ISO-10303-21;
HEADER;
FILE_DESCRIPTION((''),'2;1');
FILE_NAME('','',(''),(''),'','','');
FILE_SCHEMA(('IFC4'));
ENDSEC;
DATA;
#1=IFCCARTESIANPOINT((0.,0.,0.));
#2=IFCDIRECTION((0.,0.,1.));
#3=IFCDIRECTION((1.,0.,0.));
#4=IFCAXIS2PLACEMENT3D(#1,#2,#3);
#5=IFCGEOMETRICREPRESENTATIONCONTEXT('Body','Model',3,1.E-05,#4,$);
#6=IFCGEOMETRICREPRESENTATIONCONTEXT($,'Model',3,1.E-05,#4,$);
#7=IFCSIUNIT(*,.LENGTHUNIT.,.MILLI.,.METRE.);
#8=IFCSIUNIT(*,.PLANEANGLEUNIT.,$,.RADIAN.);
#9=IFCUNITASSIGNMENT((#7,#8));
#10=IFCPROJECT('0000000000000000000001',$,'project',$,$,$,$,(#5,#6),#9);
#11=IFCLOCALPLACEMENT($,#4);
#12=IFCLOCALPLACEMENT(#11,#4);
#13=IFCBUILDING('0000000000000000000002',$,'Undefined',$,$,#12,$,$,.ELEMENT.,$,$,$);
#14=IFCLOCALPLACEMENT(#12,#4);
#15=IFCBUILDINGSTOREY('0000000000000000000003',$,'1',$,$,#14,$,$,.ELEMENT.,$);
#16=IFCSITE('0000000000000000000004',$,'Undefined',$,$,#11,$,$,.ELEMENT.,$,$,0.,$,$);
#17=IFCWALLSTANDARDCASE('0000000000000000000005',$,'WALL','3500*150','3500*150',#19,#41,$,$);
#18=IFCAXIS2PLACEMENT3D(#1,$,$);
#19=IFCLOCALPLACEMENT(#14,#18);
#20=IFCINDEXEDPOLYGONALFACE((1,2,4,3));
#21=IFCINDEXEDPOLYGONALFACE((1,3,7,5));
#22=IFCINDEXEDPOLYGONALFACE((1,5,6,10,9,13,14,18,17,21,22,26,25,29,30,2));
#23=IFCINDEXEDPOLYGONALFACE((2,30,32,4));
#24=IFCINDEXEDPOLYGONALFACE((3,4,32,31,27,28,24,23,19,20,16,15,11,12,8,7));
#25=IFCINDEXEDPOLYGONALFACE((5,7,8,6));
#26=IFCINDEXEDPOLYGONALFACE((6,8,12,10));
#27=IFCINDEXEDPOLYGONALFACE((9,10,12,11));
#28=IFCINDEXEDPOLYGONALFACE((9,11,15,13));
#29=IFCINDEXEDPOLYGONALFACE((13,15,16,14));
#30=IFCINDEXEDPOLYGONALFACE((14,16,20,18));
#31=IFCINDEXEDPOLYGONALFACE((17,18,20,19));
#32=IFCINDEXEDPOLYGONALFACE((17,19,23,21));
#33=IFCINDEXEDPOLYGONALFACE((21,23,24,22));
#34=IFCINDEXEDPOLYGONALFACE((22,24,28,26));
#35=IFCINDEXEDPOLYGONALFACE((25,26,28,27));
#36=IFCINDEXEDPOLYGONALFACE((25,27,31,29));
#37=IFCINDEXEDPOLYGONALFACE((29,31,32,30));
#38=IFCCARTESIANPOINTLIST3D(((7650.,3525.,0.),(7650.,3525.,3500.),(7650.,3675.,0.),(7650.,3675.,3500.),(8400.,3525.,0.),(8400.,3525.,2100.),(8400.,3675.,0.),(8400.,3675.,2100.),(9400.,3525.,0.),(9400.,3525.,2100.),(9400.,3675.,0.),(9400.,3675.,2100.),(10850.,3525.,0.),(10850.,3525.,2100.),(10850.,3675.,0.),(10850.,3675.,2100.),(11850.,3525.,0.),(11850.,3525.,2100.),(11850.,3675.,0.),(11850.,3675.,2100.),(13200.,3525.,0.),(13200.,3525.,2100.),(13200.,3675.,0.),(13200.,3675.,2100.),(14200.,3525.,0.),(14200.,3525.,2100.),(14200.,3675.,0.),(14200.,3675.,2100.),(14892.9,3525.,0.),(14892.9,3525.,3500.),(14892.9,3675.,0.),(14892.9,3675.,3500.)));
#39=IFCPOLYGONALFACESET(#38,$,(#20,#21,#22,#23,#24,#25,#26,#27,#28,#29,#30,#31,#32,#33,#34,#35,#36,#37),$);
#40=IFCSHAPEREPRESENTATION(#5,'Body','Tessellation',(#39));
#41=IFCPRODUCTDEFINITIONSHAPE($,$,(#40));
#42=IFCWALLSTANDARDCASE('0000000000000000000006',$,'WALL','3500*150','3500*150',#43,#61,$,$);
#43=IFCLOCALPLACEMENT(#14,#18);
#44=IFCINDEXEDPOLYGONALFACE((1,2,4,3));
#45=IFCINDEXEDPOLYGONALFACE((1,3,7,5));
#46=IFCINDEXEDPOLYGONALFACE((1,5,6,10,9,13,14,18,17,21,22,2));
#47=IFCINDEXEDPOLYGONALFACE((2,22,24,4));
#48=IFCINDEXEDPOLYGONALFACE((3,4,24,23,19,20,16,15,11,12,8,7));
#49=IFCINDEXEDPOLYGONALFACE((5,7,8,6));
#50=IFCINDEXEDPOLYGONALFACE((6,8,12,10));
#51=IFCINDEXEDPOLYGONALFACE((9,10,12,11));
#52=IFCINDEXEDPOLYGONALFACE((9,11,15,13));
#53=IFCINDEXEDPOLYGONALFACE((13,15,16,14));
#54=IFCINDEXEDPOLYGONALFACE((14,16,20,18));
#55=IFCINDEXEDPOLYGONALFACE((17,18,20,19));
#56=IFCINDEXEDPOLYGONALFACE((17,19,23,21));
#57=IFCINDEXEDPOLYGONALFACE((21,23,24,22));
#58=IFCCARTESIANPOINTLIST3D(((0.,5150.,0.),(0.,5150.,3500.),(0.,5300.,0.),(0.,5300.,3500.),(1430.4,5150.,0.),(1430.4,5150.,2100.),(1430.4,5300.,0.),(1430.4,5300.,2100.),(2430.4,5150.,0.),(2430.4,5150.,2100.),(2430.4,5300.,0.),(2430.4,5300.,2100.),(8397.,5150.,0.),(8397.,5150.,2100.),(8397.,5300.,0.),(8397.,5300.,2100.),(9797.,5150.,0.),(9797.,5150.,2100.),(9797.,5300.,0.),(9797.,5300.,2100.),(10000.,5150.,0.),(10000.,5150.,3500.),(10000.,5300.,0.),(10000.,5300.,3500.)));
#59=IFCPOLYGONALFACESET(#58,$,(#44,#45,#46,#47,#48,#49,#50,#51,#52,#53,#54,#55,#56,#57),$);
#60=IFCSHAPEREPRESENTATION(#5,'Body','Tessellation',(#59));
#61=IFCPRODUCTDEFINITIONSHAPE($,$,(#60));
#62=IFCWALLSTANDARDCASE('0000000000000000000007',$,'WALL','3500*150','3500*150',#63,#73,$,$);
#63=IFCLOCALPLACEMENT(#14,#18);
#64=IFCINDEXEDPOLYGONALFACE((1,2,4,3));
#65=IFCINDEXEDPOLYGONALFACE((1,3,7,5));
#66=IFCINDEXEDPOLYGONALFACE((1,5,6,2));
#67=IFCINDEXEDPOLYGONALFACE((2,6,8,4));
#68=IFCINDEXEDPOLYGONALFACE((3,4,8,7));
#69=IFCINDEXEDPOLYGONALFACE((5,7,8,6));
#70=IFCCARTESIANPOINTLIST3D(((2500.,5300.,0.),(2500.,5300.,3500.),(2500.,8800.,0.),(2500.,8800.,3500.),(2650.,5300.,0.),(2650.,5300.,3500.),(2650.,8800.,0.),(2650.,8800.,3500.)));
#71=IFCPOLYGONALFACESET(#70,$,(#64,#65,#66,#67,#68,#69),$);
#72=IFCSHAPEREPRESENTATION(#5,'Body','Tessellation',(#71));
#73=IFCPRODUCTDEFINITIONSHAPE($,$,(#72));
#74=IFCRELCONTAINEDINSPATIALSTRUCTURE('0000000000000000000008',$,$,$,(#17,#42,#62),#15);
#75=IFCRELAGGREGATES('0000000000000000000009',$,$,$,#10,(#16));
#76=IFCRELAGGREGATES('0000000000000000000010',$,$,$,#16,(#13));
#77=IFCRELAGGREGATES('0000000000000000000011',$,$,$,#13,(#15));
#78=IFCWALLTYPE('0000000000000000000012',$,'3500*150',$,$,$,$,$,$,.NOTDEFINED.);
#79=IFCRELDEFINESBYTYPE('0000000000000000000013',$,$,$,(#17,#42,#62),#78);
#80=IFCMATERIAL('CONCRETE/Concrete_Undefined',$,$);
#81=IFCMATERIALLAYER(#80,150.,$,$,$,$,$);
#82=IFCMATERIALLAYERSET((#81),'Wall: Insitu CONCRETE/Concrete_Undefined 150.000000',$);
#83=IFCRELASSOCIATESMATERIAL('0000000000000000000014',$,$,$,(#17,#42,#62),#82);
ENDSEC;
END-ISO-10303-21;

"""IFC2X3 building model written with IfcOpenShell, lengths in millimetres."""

from ifc_helpers import new_model, si_unit, frame, frame_2d, origin_with_axes, place, context, project, spatial, polyline, rectangle, outline, extrude, material, layer, layer_set, layer_usage, type_object, element, save


model = new_model("IFC2X3")

# Units and contexts
model_context_1 = context("Model", 3, precision=1e-05, world=origin_with_axes(), identifier="Body")
model_context_2 = context("Model", 3, precision=1e-05, world=origin_with_axes())
ifc_project = project(units=[si_unit("LENGTHUNIT", "METRE", prefix="MILLI"), si_unit("PLANEANGLEUNIT", "RADIAN")], contexts=[model_context_1, model_context_2])

# Site, building, storey
site_placement = place(None, origin_with_axes())
site = spatial("IfcSite", under=ifc_project, at=site_placement, Name="Undefined", CompositionType="ELEMENT", RefElevation=0.0)
building_placement = place(site_placement, origin_with_axes())
building = spatial("IfcBuilding", under=site, at=building_placement, Name="Undefined", CompositionType="ELEMENT")
storey_placement = place(building_placement, origin_with_axes())
storey = spatial("IfcBuildingStorey", under=building, at=storey_placement, Name="1", CompositionType="ELEMENT")

# Shared definitions
ifc_material = material(Name="CONCRETE/Concrete_Undefined")

# Walls, openings
ifc_layer_1 = layer(ifc_material, 150.0)
ifc_layer_set_1 = layer_set([ifc_layer_1], Name="Wall: Insitu CONCRETE/Concrete_Undefined 150.000000")
ifc_layer_usage_1 = layer_usage(ifc_layer_set_1, "AXIS2", "POSITIVE", -75.0)
wall_type_1 = type_object("IfcWallType", Name="3500*150", PredefinedType="NOTDEFINED")
wall_1_placement = place(storey_placement, frame((7650.0, 3600.0, 0.0), z_axis=(0.0, 0.0, 1.0), x_axis=(1.0, 0.0, 0.0)))
wall_1 = element("IfcWallStandardCase", 1, at=wall_1_placement, inside=storey, type_object=wall_type_1, material=ifc_layer_usage_1, Name="WALL", Description="3500*150", ObjectType="3500*150", context=model_context_1, shape_type="SweptSolid", body=[
    extrude(rectangle(XDim=7242.9, YDim=150.0, at=frame_2d((0.0, 3621.4), x_axis=(0.0, -1.0))), frame((0.0, 0.0, 0.0), z_axis=(0.0, 0.0, 1.0), x_axis=(0.0, -1.0, 0.0)), (0.0, 0.0, 1.0), 3500.0),
])
opening_1_placement = place(storey_placement, frame((7650.0, 3600.0, 0.0), z_axis=(0.0, 0.0, 1.0), x_axis=(1.0, 0.0, 0.0)))
element("IfcOpeningElement", 2, at=opening_1_placement, cuts=wall_1, ObjectType="Recess", context=model_context_1, shape_type="SweptSolid", body=[
    extrude(outline(polyline([(0.0, 0.0), (1000.0, 0.0), (1000.0, 2100.0), (0.0, 2100.0), (0.0, 0.0)])), frame((750.0, -78.0, 2100.0), z_axis=(0.0, 1.0, 0.0), x_axis=(1.0, 0.0, 0.0)), (0.0, 0.0, 1.0), 156.0),
])
opening_2_placement = place(storey_placement, frame((7650.0, 3600.0, 0.0), z_axis=(0.0, 0.0, 1.0), x_axis=(1.0, 0.0, 0.0)))
element("IfcOpeningElement", 3, at=opening_2_placement, cuts=wall_1, ObjectType="Recess", context=model_context_1, shape_type="SweptSolid", body=[
    extrude(outline(polyline([(0.0, 0.0), (1000.0, 0.0), (1000.0, 2100.0), (0.0, 2100.0), (0.0, 0.0)])), frame((3200.0, -78.0, 2100.0), z_axis=(0.0, 1.0, 0.0), x_axis=(1.0, 0.0, 0.0)), (0.0, 0.0, 1.0), 156.0),
])
opening_3_placement = place(storey_placement, frame((7650.0, 3600.0, 0.0), z_axis=(0.0, 0.0, 1.0), x_axis=(1.0, 0.0, 0.0)))
element("IfcOpeningElement", 4, at=opening_3_placement, cuts=wall_1, ObjectType="Recess", context=model_context_1, shape_type="SweptSolid", body=[
    extrude(outline(polyline([(0.0, 0.0), (1000.0, 0.0), (1000.0, 2100.0), (0.0, 2100.0), (0.0, 0.0)])), frame((5550.0, -78.0, 2100.0), z_axis=(0.0, 1.0, 0.0), x_axis=(1.0, 0.0, 0.0)), (0.0, 0.0, 1.0), 156.0),
])
ifc_layer_usage_2 = layer_usage(ifc_layer_set_1, "AXIS2", "POSITIVE", -75.0)
wall_2_placement = place(storey_placement, frame((0.0, 5225.0, 0.0), z_axis=(0.0, 0.0, 1.0), x_axis=(1.0, 0.0, 0.0)))
wall_2 = element("IfcWallStandardCase", 5, at=wall_2_placement, inside=storey, type_object=wall_type_1, material=ifc_layer_usage_2, Name="WALL", Description="3500*150", ObjectType="3500*150", context=model_context_1, shape_type="SweptSolid", body=[
    extrude(rectangle(XDim=10000.0, YDim=150.0, at=frame_2d((0.0, 5000.0), x_axis=(0.0, -1.0))), frame((0.0, 0.0, 0.0), z_axis=(0.0, 0.0, 1.0), x_axis=(0.0, -1.0, 0.0)), (0.0, 0.0, 1.0), 3500.0),
])
opening_4_placement = place(storey_placement, frame((0.0, 5225.0, 0.0), z_axis=(0.0, 0.0, 1.0), x_axis=(1.0, 0.0, 0.0)))
element("IfcOpeningElement", 6, at=opening_4_placement, cuts=wall_2, ObjectType="Recess", context=model_context_1, shape_type="SweptSolid", body=[
    extrude(outline(polyline([(0.0, 0.0), (2100.0, 0.0), (2100.0, 1000.0), (0.0, 1000.0), (0.0, 0.0)])), frame((1430.4, -78.0, 0.0), z_axis=(0.0, 1.0, 0.0), x_axis=(0.0, 0.0, 1.0)), (0.0, 0.0, 1.0), 156.0),
])
opening_5_placement = place(storey_placement, frame((0.0, 5225.0, 0.0), z_axis=(0.0, 0.0, 1.0), x_axis=(1.0, 0.0, 0.0)))
element("IfcOpeningElement", 7, at=opening_5_placement, cuts=wall_2, ObjectType="Recess", context=model_context_1, shape_type="SweptSolid", body=[
    extrude(outline(polyline([(0.0, 0.0), (1400.0, 0.0), (1400.0, 2100.0), (0.0, 2100.0), (0.0, 0.0)])), frame((9797.0, 78.0, 2100.0), z_axis=(0.0, -1.0, 0.0), x_axis=(-1.0, 0.0, 0.0)), (0.0, 0.0, 1.0), 156.0),
])

# Wall
ifc_layer_usage_3 = layer_usage(ifc_layer_set_1, "AXIS2", "POSITIVE", -75.0)
wall_3_placement = place(storey_placement, frame((2575.0, 5300.0, 0.0), z_axis=(0.0, 0.0, 1.0), x_axis=(0.0, 1.0, 0.0)))
element("IfcWallStandardCase", 8, at=wall_3_placement, inside=storey, type_object=wall_type_1, material=ifc_layer_usage_3, Name="WALL", Description="3500*150", ObjectType="3500*150", context=model_context_1, shape_type="SweptSolid", body=[
    extrude(rectangle(XDim=3500.0, YDim=150.0, at=frame_2d((0.0, 1750.0), x_axis=(0.0, -1.0))), frame((0.0, 0.0, 0.0), z_axis=(0.0, 0.0, 1.0), x_axis=(0.0, -1.0, 0.0)), (0.0, 0.0, 1.0), 3500.0),
])

save(model, "model.ifc")
